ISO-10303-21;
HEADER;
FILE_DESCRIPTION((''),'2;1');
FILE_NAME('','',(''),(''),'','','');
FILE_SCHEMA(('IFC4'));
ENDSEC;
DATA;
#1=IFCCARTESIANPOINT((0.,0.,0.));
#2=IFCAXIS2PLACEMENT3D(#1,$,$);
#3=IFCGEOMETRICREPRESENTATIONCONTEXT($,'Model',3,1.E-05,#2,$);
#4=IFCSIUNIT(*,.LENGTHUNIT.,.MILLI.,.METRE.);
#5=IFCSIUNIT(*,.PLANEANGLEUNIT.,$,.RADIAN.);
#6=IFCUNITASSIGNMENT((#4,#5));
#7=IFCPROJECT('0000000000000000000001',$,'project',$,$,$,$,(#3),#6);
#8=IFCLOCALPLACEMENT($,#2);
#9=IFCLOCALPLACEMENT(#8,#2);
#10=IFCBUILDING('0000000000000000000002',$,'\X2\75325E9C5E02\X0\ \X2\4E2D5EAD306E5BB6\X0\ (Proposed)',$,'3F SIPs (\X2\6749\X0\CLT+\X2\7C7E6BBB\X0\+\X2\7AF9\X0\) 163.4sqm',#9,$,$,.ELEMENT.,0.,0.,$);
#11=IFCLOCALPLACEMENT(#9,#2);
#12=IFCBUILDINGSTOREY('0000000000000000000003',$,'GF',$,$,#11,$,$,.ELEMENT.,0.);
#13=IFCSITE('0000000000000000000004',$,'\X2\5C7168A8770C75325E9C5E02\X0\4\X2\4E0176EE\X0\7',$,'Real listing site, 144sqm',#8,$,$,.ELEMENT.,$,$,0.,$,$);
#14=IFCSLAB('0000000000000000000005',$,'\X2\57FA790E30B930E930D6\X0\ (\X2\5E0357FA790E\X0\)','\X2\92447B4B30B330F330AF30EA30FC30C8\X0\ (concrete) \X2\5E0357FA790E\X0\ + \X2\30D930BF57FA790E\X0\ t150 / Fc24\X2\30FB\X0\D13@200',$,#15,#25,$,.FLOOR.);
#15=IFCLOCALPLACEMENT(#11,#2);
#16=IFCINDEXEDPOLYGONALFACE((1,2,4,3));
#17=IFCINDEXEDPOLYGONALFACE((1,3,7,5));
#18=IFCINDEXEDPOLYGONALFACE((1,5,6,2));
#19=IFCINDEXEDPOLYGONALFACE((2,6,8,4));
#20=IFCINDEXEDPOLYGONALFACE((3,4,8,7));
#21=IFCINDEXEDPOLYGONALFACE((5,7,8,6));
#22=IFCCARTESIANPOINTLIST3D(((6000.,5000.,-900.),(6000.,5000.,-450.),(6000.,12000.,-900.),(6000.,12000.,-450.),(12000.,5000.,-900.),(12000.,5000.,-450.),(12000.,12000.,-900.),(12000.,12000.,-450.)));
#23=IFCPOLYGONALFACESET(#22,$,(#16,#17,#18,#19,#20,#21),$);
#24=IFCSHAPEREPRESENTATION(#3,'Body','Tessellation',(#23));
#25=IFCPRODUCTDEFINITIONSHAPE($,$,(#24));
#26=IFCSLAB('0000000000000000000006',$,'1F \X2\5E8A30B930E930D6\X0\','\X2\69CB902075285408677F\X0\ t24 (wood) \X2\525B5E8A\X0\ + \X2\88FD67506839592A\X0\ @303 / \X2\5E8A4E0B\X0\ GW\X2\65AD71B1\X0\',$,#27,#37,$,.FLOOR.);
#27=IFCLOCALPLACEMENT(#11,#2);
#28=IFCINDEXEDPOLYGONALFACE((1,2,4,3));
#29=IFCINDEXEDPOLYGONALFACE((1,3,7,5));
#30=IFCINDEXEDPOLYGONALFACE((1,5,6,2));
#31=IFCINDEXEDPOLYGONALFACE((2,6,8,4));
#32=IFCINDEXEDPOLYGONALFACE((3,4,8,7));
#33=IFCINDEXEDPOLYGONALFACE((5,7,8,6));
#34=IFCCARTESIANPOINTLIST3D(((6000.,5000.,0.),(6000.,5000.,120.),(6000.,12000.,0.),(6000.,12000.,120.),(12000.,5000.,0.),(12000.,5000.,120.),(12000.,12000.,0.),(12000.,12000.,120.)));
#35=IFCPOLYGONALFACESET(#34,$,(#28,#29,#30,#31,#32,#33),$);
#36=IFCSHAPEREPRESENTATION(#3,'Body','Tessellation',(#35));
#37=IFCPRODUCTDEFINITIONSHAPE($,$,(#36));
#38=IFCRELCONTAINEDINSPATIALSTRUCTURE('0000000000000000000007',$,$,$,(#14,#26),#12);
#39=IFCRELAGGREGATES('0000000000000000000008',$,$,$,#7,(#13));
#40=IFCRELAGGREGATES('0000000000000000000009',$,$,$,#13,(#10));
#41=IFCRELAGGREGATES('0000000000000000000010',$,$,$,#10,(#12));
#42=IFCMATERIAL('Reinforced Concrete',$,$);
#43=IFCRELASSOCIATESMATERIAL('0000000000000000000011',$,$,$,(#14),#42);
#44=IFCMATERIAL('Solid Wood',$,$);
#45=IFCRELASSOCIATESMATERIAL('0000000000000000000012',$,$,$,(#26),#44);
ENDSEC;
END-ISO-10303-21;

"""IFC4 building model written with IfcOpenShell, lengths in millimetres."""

from ifc_helpers import new_model, si_unit, frame, frame_2d, origin, place, context, project, spatial, rectangle, extrude, material, element, save


model = new_model("IFC4")

# Units and contexts
model_context = context("Model", 3, precision=1e-05, world=origin())
ifc_project = project(units=[si_unit("LENGTHUNIT", "METRE", prefix="MILLI"), si_unit("PLANEANGLEUNIT", "RADIAN")], contexts=[model_context])

# Site, building, storey
site_placement = place(None, origin())
site = spatial("IfcSite", under=ifc_project, at=site_placement, Name="山梨県甲府市4丁目7", ObjectType="Real listing site, 144sqm", CompositionType="ELEMENT", RefElevation=0.0)
building_placement = place(site_placement, origin())
building = spatial("IfcBuilding", under=site, at=building_placement, Name="甲府市 中庭の家 (Proposed)", ObjectType="3F SIPs (杉CLT+籾殻+竹) 163.4sqm", CompositionType="ELEMENT", ElevationOfRefHeight=0.0, ElevationOfTerrain=0.0)
storey_placement = place(building_placement, origin())
storey = spatial("IfcBuildingStorey", under=building, at=storey_placement, Name="GF", CompositionType="ELEMENT", Elevation=0.0)

# Slabs
ifc_material_1 = material(Name="Reinforced Concrete")
slab_1_placement = place(storey_placement, frame((3000.0, 2500.0, -450.0)))
element("IfcSlab", 1, at=slab_1_placement, inside=storey, material=ifc_material_1, Name="基礎スラブ (布基礎)", Description="鉄筋コンクリート (concrete) 布基礎 + ベタ基礎 t150 / Fc24・D13@200", PredefinedType="FLOOR", context=model_context, shape_type="SweptSolid", body=[
    extrude(rectangle(XDim=6000.0, YDim=7000.0, at=frame_2d((3000.0, 3500.0))), frame((3000.0, 2500.0, -450.0)), (0.0, 0.0, 1.0), 450.0),
])
ifc_material_2 = material(Name="Solid Wood")
slab_2_placement = place(storey_placement, frame((3000.0, 2500.0, 0.0)))
element("IfcSlab", 2, at=slab_2_placement, inside=storey, material=ifc_material_2, Name="1F 床スラブ", Description="構造用合板 t24 (wood) 剛床 + 製材根太 @303 / 床下 GW断熱", PredefinedType="FLOOR", context=model_context, shape_type="SweptSolid", body=[
    extrude(rectangle(XDim=6000.0, YDim=7000.0, at=frame_2d((3000.0, 3500.0))), frame((3000.0, 2500.0, 0.0)), (0.0, 0.0, 1.0), 120.0),
])

save(model, "model.ifc")
